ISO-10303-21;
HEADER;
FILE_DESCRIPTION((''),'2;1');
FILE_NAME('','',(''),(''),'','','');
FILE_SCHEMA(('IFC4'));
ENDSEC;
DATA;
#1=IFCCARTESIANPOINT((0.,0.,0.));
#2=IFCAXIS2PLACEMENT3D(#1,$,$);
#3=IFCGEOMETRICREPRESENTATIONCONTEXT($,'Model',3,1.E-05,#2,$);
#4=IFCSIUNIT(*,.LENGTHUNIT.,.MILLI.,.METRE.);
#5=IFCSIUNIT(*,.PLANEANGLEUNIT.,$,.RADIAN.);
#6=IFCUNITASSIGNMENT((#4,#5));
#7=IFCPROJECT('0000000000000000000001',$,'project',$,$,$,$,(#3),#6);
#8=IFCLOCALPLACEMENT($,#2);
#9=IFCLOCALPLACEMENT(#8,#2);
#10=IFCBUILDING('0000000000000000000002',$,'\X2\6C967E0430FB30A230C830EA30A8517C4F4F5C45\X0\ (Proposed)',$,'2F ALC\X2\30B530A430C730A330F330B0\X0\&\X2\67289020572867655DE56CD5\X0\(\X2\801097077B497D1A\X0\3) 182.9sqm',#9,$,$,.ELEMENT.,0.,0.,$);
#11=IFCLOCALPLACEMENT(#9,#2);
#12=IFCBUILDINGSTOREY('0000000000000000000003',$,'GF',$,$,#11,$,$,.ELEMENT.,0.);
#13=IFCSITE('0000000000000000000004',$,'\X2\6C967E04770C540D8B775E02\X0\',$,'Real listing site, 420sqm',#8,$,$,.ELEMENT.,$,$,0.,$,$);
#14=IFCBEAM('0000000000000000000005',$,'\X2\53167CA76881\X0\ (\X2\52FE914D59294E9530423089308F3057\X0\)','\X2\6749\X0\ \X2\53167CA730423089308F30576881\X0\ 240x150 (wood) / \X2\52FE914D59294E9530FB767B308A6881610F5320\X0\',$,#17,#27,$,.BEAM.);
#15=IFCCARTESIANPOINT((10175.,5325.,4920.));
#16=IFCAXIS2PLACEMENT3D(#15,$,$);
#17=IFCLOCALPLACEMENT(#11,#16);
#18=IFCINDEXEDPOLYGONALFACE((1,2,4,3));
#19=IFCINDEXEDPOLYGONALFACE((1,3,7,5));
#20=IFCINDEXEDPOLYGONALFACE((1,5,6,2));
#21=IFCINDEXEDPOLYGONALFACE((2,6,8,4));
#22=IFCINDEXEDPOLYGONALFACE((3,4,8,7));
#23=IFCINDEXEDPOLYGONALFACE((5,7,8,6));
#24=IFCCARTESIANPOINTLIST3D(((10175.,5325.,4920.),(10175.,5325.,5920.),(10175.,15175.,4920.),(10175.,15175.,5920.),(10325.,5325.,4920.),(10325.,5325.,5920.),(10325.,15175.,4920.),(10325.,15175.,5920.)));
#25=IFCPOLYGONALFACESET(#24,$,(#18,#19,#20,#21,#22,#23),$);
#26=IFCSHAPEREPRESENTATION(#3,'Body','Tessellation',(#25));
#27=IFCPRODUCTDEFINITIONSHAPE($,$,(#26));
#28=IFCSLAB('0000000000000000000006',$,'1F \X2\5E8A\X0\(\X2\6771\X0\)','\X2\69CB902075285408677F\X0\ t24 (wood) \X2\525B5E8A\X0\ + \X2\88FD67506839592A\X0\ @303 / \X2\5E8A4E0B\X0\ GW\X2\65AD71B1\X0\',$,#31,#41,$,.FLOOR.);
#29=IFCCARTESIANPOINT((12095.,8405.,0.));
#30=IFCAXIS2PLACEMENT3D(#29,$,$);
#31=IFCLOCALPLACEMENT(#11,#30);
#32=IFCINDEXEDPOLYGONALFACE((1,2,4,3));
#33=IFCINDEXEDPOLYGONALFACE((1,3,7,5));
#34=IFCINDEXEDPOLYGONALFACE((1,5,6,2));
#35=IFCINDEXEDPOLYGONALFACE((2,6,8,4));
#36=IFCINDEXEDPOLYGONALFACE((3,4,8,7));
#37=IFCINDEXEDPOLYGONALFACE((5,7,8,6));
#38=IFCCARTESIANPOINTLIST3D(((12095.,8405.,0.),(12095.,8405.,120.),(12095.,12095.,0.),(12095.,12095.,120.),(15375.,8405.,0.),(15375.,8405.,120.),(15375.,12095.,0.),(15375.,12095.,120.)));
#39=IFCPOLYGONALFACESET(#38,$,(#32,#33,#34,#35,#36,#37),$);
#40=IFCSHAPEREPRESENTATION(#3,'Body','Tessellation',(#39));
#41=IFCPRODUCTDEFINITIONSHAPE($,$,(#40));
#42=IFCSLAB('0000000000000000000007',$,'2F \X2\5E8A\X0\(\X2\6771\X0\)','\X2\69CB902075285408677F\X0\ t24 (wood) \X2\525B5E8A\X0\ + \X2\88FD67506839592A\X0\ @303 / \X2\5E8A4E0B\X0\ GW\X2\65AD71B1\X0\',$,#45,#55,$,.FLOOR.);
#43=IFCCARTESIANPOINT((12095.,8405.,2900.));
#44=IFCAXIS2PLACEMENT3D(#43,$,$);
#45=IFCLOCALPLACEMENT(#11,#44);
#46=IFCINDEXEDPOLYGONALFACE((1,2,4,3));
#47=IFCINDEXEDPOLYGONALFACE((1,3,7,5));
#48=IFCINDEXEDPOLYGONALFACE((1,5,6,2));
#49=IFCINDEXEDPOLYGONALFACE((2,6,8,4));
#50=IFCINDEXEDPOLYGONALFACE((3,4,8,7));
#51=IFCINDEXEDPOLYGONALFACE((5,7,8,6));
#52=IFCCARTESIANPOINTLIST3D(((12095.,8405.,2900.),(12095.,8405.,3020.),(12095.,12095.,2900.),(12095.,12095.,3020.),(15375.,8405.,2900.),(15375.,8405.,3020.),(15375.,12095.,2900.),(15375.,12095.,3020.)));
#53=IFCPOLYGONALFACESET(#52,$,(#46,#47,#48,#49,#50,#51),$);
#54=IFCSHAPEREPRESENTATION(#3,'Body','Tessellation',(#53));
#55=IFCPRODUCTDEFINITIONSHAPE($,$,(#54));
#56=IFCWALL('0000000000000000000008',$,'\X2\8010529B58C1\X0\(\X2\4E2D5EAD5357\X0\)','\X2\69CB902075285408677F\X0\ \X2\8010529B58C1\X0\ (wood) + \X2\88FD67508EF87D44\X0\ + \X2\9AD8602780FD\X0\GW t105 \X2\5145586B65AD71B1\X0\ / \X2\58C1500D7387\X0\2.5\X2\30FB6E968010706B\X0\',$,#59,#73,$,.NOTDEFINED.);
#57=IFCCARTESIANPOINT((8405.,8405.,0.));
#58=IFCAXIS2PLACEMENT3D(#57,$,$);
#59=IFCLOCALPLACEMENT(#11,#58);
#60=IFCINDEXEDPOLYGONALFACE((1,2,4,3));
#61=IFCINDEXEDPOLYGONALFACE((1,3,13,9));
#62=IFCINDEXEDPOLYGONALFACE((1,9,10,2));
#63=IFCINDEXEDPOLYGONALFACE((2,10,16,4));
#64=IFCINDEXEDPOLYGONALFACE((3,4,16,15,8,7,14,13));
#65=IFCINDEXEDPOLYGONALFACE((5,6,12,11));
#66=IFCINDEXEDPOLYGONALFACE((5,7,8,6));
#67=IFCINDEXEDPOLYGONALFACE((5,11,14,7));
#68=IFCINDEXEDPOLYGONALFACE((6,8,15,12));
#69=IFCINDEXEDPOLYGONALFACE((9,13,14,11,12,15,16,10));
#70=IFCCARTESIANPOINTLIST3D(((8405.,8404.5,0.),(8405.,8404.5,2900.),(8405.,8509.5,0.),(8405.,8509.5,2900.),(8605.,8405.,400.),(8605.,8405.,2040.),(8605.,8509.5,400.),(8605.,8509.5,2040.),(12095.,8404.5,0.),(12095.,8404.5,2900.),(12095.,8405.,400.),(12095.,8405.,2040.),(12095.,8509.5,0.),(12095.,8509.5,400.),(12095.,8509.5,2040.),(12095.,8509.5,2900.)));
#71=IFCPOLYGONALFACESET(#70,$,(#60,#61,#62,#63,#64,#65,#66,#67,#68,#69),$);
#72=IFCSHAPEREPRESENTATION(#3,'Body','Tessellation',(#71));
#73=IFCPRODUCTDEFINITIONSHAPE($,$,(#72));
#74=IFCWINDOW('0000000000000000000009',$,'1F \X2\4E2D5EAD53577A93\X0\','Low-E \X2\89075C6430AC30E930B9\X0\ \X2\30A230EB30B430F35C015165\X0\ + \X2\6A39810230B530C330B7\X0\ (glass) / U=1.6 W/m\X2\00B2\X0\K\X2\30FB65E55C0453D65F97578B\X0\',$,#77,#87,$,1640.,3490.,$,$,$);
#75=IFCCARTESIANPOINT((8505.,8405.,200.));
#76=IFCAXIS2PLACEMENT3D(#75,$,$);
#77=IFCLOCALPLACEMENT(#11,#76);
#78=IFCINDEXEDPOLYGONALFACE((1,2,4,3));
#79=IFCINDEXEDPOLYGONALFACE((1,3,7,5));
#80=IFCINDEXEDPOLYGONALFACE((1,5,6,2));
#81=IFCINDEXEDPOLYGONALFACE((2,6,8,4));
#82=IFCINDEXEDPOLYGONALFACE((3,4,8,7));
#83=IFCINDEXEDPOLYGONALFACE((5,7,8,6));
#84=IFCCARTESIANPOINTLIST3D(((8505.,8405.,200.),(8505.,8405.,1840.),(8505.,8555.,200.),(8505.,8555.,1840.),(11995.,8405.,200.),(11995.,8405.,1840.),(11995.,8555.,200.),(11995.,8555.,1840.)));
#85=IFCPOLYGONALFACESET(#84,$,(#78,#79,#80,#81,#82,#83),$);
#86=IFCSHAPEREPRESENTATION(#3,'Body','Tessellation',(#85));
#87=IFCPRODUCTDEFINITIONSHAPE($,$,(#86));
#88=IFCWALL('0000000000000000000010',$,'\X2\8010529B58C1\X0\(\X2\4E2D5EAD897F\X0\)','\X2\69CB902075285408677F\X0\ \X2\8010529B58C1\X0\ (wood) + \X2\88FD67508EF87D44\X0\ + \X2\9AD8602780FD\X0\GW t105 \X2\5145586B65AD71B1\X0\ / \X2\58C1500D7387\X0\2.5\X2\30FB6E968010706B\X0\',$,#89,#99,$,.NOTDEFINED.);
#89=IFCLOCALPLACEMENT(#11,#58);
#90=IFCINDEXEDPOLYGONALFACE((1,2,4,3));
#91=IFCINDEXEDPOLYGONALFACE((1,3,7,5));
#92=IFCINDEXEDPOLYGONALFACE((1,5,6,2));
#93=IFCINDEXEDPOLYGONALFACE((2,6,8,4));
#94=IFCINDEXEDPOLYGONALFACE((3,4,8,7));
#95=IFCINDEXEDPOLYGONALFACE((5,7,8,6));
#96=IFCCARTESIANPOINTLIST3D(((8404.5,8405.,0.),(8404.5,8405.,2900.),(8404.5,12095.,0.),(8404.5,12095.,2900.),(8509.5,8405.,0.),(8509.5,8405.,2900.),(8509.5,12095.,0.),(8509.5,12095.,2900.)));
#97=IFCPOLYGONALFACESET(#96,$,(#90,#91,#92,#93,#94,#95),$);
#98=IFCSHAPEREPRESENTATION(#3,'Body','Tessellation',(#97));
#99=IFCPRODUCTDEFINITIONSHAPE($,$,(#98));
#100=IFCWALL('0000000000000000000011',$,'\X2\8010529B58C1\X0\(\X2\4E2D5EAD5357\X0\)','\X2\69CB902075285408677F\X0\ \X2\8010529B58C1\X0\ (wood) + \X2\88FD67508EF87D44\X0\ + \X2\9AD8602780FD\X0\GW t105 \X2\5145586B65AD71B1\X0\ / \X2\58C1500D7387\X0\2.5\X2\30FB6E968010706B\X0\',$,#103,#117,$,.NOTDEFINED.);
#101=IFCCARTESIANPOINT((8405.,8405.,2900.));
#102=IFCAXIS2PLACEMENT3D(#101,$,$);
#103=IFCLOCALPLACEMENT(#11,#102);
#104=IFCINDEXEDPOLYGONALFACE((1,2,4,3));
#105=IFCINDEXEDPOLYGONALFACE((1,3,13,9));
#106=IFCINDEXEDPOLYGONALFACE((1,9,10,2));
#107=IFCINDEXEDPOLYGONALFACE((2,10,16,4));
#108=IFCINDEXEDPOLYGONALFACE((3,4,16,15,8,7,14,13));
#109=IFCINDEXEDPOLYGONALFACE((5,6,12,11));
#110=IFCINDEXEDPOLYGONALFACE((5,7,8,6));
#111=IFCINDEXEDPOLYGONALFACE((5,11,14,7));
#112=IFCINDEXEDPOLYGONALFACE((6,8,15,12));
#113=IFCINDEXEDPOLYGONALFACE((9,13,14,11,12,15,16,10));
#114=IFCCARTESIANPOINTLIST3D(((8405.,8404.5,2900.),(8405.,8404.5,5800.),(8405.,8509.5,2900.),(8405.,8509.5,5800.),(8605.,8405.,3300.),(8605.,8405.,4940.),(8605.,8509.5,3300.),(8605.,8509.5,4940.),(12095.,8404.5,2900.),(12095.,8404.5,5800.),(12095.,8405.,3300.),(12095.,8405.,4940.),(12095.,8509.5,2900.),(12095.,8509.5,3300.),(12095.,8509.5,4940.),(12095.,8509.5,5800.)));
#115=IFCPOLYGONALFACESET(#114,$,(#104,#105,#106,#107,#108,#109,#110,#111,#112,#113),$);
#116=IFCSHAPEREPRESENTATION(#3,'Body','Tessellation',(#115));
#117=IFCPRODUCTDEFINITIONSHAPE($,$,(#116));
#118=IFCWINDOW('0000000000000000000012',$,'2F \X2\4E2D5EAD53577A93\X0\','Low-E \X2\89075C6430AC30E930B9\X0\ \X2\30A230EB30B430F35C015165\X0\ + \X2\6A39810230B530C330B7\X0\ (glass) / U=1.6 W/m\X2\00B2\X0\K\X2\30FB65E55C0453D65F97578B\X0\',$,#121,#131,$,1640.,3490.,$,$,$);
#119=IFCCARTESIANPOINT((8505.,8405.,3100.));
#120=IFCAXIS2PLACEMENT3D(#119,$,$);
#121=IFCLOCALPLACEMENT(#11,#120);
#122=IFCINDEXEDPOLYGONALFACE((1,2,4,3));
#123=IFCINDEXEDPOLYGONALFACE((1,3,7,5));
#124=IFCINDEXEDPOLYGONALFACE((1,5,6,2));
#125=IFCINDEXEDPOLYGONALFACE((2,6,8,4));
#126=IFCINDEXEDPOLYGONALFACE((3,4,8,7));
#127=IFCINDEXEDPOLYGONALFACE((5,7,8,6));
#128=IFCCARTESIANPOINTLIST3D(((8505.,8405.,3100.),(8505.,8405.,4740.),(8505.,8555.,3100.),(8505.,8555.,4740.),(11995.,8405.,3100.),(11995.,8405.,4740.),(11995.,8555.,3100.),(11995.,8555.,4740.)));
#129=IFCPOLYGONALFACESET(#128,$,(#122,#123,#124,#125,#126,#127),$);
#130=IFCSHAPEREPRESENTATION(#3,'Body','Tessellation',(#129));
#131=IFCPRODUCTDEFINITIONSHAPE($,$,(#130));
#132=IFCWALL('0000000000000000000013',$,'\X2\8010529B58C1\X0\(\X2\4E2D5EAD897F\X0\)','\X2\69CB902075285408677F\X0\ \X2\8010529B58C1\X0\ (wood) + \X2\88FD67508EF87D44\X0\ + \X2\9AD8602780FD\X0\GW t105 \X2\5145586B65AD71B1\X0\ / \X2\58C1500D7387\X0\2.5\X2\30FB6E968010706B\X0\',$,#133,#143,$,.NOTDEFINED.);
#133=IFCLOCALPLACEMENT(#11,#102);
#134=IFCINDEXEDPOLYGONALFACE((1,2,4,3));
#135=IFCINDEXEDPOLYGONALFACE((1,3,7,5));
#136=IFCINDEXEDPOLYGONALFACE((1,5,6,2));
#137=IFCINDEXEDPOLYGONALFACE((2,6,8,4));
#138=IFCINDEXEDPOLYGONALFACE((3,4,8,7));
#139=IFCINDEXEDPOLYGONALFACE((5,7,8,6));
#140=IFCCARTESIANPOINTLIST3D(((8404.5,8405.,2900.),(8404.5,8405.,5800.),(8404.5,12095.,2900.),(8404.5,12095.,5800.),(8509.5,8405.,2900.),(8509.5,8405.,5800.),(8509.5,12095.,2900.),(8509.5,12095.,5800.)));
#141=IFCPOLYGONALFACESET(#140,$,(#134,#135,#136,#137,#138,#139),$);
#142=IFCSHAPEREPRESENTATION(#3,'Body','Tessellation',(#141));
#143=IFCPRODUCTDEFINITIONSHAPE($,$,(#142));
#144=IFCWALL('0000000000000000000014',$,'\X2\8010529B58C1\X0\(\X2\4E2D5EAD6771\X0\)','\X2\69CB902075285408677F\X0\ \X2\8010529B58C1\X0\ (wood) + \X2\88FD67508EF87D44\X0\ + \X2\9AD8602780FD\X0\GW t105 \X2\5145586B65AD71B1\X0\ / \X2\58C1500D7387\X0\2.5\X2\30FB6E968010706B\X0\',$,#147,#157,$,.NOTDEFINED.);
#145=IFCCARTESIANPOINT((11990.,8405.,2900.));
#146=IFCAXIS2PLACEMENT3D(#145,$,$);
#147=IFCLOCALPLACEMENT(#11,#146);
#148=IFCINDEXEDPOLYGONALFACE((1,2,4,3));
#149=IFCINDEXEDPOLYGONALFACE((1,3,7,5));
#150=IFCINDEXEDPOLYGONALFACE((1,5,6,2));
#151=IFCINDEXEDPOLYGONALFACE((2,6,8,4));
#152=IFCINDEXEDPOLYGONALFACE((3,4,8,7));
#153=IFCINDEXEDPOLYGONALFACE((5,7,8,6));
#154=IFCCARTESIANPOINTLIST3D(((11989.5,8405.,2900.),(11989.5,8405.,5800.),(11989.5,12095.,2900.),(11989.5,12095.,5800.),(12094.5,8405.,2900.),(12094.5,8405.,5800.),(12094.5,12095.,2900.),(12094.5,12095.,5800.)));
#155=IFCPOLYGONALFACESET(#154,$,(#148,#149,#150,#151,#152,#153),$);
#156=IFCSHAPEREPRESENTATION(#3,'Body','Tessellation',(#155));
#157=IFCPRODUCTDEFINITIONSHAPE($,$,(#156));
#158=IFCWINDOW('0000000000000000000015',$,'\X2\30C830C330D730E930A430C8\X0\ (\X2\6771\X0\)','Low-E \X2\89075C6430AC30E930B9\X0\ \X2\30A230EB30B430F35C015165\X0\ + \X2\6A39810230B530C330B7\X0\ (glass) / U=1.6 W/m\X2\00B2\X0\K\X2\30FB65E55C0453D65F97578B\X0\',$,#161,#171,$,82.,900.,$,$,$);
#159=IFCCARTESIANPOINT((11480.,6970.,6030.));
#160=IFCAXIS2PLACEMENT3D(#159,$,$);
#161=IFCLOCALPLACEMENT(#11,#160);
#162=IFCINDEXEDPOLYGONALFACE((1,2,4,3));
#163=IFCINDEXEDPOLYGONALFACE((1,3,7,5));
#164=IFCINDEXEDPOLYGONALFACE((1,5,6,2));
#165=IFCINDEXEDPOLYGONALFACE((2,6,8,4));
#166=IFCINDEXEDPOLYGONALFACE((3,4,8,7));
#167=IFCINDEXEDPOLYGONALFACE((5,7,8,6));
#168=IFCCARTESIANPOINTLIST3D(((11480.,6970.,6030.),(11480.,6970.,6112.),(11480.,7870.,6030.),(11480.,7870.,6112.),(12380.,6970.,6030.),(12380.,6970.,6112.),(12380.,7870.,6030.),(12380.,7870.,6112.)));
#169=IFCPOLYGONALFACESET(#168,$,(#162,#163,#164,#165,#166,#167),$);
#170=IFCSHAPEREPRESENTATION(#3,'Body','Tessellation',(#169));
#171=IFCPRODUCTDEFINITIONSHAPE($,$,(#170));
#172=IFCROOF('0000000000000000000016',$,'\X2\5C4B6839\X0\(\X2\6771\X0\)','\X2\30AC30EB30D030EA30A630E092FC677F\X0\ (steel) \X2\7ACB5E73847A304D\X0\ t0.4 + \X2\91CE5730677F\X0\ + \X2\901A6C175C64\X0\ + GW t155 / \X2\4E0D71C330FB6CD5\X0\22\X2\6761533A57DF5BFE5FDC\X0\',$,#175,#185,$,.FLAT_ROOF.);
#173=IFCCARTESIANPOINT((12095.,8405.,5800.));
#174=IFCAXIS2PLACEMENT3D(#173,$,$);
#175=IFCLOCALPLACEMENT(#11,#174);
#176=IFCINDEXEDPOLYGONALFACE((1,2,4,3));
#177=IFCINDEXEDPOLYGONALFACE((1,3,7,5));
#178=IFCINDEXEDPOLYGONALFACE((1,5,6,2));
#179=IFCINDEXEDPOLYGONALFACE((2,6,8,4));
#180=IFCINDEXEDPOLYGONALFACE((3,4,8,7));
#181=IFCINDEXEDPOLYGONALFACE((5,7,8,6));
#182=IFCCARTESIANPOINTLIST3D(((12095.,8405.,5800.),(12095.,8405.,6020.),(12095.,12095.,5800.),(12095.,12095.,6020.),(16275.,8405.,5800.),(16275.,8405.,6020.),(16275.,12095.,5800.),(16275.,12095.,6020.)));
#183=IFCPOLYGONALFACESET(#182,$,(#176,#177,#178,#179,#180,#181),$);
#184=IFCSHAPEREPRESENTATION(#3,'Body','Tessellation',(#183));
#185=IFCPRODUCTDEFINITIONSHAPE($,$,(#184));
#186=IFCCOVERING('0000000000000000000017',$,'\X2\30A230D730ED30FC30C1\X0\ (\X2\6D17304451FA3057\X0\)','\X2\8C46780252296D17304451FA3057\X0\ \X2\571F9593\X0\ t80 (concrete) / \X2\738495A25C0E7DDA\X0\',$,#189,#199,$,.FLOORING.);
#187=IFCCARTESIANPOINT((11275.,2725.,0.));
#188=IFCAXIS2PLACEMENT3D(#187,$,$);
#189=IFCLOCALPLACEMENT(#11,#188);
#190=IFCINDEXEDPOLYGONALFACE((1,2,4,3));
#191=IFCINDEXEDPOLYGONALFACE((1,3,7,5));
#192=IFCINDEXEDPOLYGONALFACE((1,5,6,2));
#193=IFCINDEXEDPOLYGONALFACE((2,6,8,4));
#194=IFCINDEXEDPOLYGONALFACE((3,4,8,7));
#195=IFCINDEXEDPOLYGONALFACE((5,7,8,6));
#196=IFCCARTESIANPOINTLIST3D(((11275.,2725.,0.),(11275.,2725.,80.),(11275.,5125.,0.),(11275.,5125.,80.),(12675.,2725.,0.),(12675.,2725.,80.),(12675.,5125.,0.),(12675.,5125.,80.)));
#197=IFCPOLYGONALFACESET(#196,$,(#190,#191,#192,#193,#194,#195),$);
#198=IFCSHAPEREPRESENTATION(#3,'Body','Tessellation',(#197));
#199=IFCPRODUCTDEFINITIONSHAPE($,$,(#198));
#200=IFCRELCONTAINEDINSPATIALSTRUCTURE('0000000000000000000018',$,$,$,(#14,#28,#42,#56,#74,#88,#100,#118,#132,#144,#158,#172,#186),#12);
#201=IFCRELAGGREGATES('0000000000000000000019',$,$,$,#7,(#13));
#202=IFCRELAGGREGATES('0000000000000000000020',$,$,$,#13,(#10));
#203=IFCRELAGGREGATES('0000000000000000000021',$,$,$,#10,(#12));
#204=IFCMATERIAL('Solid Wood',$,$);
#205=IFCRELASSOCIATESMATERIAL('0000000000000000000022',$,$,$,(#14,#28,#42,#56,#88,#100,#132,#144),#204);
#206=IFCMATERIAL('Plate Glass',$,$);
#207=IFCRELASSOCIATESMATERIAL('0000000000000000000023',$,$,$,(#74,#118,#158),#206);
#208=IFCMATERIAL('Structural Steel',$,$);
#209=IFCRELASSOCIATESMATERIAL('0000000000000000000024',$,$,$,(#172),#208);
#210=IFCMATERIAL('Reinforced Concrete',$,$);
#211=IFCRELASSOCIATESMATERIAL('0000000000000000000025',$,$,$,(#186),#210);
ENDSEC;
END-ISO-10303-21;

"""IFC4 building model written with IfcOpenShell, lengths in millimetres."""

from ifc_helpers import new_model, si_unit, frame, frame_2d, origin, place, context, project, spatial, rectangle, extrude, material, element, fill, save


model = new_model("IFC4")

# Units and contexts
model_context = context("Model", 3, precision=1e-05, world=origin())
ifc_project = project(units=[si_unit("LENGTHUNIT", "METRE", prefix="MILLI"), si_unit("PLANEANGLEUNIT", "RADIAN")], contexts=[model_context])

# Site, building, storey
site_placement = place(None, origin())
site = spatial("IfcSite", under=ifc_project, at=site_placement, Name="沖縄県名護市", ObjectType="Real listing site, 420sqm", CompositionType="ELEMENT", RefElevation=0.0)
building_placement = place(site_placement, origin())
building = spatial("IfcBuilding", under=site, at=building_placement, Name="沖縄・アトリエ兼住居 (Proposed)", ObjectType="2F ALCサイディング&木造在来工法(耐震等級3) 182.9sqm", CompositionType="ELEMENT", ElevationOfRefHeight=0.0, ElevationOfTerrain=0.0)
storey_placement = place(building_placement, origin())
storey = spatial("IfcBuildingStorey", under=building, at=storey_placement, Name="GF", CompositionType="ELEMENT", Elevation=0.0)

# Shared definitions
ifc_material_1 = material(Name="Solid Wood")

# Beam
beam_placement = place(storey_placement, frame((10175.0, 5325.0, 4920.0)))
element("IfcBeam", 1, at=beam_placement, inside=storey, material=ifc_material_1, Name="化粧梁 (勾配天井あらわし)", Description="杉 化粧あらわし梁 240x150 (wood) / 勾配天井・登り梁意匠", PredefinedType="BEAM", context=model_context, shape_type="SweptSolid", body=[
    extrude(rectangle(XDim=150.0, YDim=9850.0, at=frame_2d((75.0, 4925.0))), frame((10175.0, 5325.0, 4920.0)), (0.0, 0.0, 1.0), 1000.0),
])

# Slabs
slab_1_placement = place(storey_placement, frame((12095.0, 8405.0, 0.0)))
element("IfcSlab", 2, at=slab_1_placement, inside=storey, material=ifc_material_1, Name="1F 床(東)", Description="構造用合板 t24 (wood) 剛床 + 製材根太 @303 / 床下 GW断熱", PredefinedType="FLOOR", context=model_context, shape_type="SweptSolid", body=[
    extrude(rectangle(XDim=3280.0, YDim=3690.0, at=frame_2d((1640.0, 1845.0))), frame((12095.0, 8405.0, 0.0)), (0.0, 0.0, 1.0), 120.0),
])
slab_2_placement = place(storey_placement, frame((12095.0, 8405.0, 2900.0)))
element("IfcSlab", 3, at=slab_2_placement, inside=storey, material=ifc_material_1, Name="2F 床(東)", Description="構造用合板 t24 (wood) 剛床 + 製材根太 @303 / 床下 GW断熱", PredefinedType="FLOOR", context=model_context, shape_type="SweptSolid", body=[
    extrude(rectangle(XDim=3280.0, YDim=3690.0, at=frame_2d((1640.0, 1845.0))), frame((12095.0, 8405.0, 2900.0)), (0.0, 0.0, 1.0), 120.0),
])

# Wall, opening, window
wall_1_placement = place(storey_placement, frame((8405.0, 8405.0, 0.0)))
wall_1 = element("IfcWall", 4, at=wall_1_placement, inside=storey, material=ifc_material_1, Name="耐力壁(中庭南)", Description="構造用合板 耐力壁 (wood) + 製材軸組 + 高性能GW t105 充填断熱 / 壁倍率2.5・準耐火", PredefinedType="NOTDEFINED", context=model_context, shape_type="SweptSolid", body=[
    extrude(rectangle(XDim=3690.0, YDim=105.0, at=frame_2d((1845.0, 52.0))), frame((8405.0, 8405.0, 0.0)), (0.0, 0.0, 1.0), 2900.0),
])
opening_1_placement = place(storey_placement, frame((8505.0, 8405.0, 200.0)))
opening_1 = element("IfcOpeningElement", 5, at=opening_1_placement, cuts=wall_1, PredefinedType="NOTDEFINED", context=model_context, shape_type="SweptSolid", body=[
    extrude(rectangle(XDim=3490.0, YDim=150.0, at=frame_2d((1745.0, 75.0))), frame((8505.0, 8405.0, 200.0)), (0.0, 0.0, 1.0), 1640.0),
])
ifc_material_2 = material(Name="Plate Glass")
window_1_placement = place(storey_placement, frame((8505.0, 8405.0, 200.0)))
window_1 = element("IfcWindow", 6, at=window_1_placement, inside=storey, material=ifc_material_2, Name="1F 中庭南窓", Description="Low-E 複層ガラス アルゴン封入 + 樹脂サッシ (glass) / U=1.6 W/m²K・日射取得型", OverallHeight=1640.0, OverallWidth=3490.0, context=model_context, shape_type="SweptSolid", body=[
    extrude(rectangle(XDim=3490.0, YDim=150.0, at=frame_2d((1745.0, 75.0))), frame((8505.0, 8405.0, 200.0)), (0.0, 0.0, 1.0), 1640.0),
])
fill(opening_1, window_1)

# Wall
wall_2_placement = place(storey_placement, frame((8405.0, 8405.0, 0.0)))
element("IfcWall", 7, at=wall_2_placement, inside=storey, material=ifc_material_1, Name="耐力壁(中庭西)", Description="構造用合板 耐力壁 (wood) + 製材軸組 + 高性能GW t105 充填断熱 / 壁倍率2.5・準耐火", PredefinedType="NOTDEFINED", context=model_context, shape_type="SweptSolid", body=[
    extrude(rectangle(XDim=105.0, YDim=3690.0, at=frame_2d((52.0, 1845.0))), frame((8405.0, 8405.0, 0.0)), (0.0, 0.0, 1.0), 2900.0),
])

# Wall, opening, window
wall_3_placement = place(storey_placement, frame((8405.0, 8405.0, 2900.0)))
wall_3 = element("IfcWall", 8, at=wall_3_placement, inside=storey, material=ifc_material_1, Name="耐力壁(中庭南)", Description="構造用合板 耐力壁 (wood) + 製材軸組 + 高性能GW t105 充填断熱 / 壁倍率2.5・準耐火", PredefinedType="NOTDEFINED", context=model_context, shape_type="SweptSolid", body=[
    extrude(rectangle(XDim=3690.0, YDim=105.0, at=frame_2d((1845.0, 52.0))), frame((8405.0, 8405.0, 2900.0)), (0.0, 0.0, 1.0), 2900.0),
])
opening_2_placement = place(storey_placement, frame((8505.0, 8405.0, 3100.0)))
opening_2 = element("IfcOpeningElement", 9, at=opening_2_placement, cuts=wall_3, PredefinedType="NOTDEFINED", context=model_context, shape_type="SweptSolid", body=[
    extrude(rectangle(XDim=3490.0, YDim=150.0, at=frame_2d((1745.0, 75.0))), frame((8505.0, 8405.0, 3100.0)), (0.0, 0.0, 1.0), 1640.0),
])
window_2_placement = place(storey_placement, frame((8505.0, 8405.0, 3100.0)))
window_2 = element("IfcWindow", 10, at=window_2_placement, inside=storey, material=ifc_material_2, Name="2F 中庭南窓", Description="Low-E 複層ガラス アルゴン封入 + 樹脂サッシ (glass) / U=1.6 W/m²K・日射取得型", OverallHeight=1640.0, OverallWidth=3490.0, context=model_context, shape_type="SweptSolid", body=[
    extrude(rectangle(XDim=3490.0, YDim=150.0, at=frame_2d((1745.0, 75.0))), frame((8505.0, 8405.0, 3100.0)), (0.0, 0.0, 1.0), 1640.0),
])
fill(opening_2, window_2)

# Walls
wall_4_placement = place(storey_placement, frame((8405.0, 8405.0, 2900.0)))
element("IfcWall", 11, at=wall_4_placement, inside=storey, material=ifc_material_1, Name="耐力壁(中庭西)", Description="構造用合板 耐力壁 (wood) + 製材軸組 + 高性能GW t105 充填断熱 / 壁倍率2.5・準耐火", PredefinedType="NOTDEFINED", context=model_context, shape_type="SweptSolid", body=[
    extrude(rectangle(XDim=105.0, YDim=3690.0, at=frame_2d((52.0, 1845.0))), frame((8405.0, 8405.0, 2900.0)), (0.0, 0.0, 1.0), 2900.0),
])
wall_5_placement = place(storey_placement, frame((11990.0, 8405.0, 2900.0)))
element("IfcWall", 12, at=wall_5_placement, inside=storey, material=ifc_material_1, Name="耐力壁(中庭東)", Description="構造用合板 耐力壁 (wood) + 製材軸組 + 高性能GW t105 充填断熱 / 壁倍率2.5・準耐火", PredefinedType="NOTDEFINED", context=model_context, shape_type="SweptSolid", body=[
    extrude(rectangle(XDim=105.0, YDim=3690.0, at=frame_2d((52.0, 1845.0))), frame((11990.0, 8405.0, 2900.0)), (0.0, 0.0, 1.0), 2900.0),
])

# Window
window_3_placement = place(storey_placement, frame((11480.0, 6970.0, 6030.0)))
element("IfcWindow", 13, at=window_3_placement, inside=storey, material=ifc_material_2, Name="トップライト (東)", Description="Low-E 複層ガラス アルゴン封入 + 樹脂サッシ (glass) / U=1.6 W/m²K・日射取得型", OverallHeight=82.0, OverallWidth=900.0, context=model_context, shape_type="SweptSolid", body=[
    extrude(rectangle(XDim=900.0, YDim=900.0, at=frame_2d((450.0, 450.0))), frame((11480.0, 6970.0, 6030.0)), (0.0, 0.0, 1.0), 82.0),
])

# Roof
ifc_material_3 = material(Name="Structural Steel")
roof_placement = place(storey_placement, frame((12095.0, 8405.0, 5800.0)))
element("IfcRoof", 14, at=roof_placement, inside=storey, material=ifc_material_3, Name="屋根(東)", Description="ガルバリウム鋼板 (steel) 立平葺き t0.4 + 野地板 + 通気層 + GW t155 / 不燃・法22条区域対応", PredefinedType="FLAT_ROOF", context=model_context, shape_type="SweptSolid", body=[
    extrude(rectangle(XDim=4180.0, YDim=3690.0, at=frame_2d((2090.0, 1845.0))), frame((12095.0, 8405.0, 5800.0)), (0.0, 0.0, 1.0), 220.0),
])

# Covering
ifc_material_4 = material(Name="Reinforced Concrete")
covering_placement = place(storey_placement, frame((11275.0, 2725.0, 0.0)))
element("IfcCovering", 15, at=covering_placement, inside=storey, material=ifc_material_4, Name="アプローチ (洗い出し)", Description="豆砂利洗い出し 土間 t80 (concrete) / 玄関導線", PredefinedType="FLOORING", context=model_context, shape_type="SweptSolid", body=[
    extrude(rectangle(XDim=1400.0, YDim=2400.0, at=frame_2d((700.0, 1200.0))), frame((11275.0, 2725.0, 0.0)), (0.0, 0.0, 1.0), 80.0),
])

save(model, "model.ifc")
